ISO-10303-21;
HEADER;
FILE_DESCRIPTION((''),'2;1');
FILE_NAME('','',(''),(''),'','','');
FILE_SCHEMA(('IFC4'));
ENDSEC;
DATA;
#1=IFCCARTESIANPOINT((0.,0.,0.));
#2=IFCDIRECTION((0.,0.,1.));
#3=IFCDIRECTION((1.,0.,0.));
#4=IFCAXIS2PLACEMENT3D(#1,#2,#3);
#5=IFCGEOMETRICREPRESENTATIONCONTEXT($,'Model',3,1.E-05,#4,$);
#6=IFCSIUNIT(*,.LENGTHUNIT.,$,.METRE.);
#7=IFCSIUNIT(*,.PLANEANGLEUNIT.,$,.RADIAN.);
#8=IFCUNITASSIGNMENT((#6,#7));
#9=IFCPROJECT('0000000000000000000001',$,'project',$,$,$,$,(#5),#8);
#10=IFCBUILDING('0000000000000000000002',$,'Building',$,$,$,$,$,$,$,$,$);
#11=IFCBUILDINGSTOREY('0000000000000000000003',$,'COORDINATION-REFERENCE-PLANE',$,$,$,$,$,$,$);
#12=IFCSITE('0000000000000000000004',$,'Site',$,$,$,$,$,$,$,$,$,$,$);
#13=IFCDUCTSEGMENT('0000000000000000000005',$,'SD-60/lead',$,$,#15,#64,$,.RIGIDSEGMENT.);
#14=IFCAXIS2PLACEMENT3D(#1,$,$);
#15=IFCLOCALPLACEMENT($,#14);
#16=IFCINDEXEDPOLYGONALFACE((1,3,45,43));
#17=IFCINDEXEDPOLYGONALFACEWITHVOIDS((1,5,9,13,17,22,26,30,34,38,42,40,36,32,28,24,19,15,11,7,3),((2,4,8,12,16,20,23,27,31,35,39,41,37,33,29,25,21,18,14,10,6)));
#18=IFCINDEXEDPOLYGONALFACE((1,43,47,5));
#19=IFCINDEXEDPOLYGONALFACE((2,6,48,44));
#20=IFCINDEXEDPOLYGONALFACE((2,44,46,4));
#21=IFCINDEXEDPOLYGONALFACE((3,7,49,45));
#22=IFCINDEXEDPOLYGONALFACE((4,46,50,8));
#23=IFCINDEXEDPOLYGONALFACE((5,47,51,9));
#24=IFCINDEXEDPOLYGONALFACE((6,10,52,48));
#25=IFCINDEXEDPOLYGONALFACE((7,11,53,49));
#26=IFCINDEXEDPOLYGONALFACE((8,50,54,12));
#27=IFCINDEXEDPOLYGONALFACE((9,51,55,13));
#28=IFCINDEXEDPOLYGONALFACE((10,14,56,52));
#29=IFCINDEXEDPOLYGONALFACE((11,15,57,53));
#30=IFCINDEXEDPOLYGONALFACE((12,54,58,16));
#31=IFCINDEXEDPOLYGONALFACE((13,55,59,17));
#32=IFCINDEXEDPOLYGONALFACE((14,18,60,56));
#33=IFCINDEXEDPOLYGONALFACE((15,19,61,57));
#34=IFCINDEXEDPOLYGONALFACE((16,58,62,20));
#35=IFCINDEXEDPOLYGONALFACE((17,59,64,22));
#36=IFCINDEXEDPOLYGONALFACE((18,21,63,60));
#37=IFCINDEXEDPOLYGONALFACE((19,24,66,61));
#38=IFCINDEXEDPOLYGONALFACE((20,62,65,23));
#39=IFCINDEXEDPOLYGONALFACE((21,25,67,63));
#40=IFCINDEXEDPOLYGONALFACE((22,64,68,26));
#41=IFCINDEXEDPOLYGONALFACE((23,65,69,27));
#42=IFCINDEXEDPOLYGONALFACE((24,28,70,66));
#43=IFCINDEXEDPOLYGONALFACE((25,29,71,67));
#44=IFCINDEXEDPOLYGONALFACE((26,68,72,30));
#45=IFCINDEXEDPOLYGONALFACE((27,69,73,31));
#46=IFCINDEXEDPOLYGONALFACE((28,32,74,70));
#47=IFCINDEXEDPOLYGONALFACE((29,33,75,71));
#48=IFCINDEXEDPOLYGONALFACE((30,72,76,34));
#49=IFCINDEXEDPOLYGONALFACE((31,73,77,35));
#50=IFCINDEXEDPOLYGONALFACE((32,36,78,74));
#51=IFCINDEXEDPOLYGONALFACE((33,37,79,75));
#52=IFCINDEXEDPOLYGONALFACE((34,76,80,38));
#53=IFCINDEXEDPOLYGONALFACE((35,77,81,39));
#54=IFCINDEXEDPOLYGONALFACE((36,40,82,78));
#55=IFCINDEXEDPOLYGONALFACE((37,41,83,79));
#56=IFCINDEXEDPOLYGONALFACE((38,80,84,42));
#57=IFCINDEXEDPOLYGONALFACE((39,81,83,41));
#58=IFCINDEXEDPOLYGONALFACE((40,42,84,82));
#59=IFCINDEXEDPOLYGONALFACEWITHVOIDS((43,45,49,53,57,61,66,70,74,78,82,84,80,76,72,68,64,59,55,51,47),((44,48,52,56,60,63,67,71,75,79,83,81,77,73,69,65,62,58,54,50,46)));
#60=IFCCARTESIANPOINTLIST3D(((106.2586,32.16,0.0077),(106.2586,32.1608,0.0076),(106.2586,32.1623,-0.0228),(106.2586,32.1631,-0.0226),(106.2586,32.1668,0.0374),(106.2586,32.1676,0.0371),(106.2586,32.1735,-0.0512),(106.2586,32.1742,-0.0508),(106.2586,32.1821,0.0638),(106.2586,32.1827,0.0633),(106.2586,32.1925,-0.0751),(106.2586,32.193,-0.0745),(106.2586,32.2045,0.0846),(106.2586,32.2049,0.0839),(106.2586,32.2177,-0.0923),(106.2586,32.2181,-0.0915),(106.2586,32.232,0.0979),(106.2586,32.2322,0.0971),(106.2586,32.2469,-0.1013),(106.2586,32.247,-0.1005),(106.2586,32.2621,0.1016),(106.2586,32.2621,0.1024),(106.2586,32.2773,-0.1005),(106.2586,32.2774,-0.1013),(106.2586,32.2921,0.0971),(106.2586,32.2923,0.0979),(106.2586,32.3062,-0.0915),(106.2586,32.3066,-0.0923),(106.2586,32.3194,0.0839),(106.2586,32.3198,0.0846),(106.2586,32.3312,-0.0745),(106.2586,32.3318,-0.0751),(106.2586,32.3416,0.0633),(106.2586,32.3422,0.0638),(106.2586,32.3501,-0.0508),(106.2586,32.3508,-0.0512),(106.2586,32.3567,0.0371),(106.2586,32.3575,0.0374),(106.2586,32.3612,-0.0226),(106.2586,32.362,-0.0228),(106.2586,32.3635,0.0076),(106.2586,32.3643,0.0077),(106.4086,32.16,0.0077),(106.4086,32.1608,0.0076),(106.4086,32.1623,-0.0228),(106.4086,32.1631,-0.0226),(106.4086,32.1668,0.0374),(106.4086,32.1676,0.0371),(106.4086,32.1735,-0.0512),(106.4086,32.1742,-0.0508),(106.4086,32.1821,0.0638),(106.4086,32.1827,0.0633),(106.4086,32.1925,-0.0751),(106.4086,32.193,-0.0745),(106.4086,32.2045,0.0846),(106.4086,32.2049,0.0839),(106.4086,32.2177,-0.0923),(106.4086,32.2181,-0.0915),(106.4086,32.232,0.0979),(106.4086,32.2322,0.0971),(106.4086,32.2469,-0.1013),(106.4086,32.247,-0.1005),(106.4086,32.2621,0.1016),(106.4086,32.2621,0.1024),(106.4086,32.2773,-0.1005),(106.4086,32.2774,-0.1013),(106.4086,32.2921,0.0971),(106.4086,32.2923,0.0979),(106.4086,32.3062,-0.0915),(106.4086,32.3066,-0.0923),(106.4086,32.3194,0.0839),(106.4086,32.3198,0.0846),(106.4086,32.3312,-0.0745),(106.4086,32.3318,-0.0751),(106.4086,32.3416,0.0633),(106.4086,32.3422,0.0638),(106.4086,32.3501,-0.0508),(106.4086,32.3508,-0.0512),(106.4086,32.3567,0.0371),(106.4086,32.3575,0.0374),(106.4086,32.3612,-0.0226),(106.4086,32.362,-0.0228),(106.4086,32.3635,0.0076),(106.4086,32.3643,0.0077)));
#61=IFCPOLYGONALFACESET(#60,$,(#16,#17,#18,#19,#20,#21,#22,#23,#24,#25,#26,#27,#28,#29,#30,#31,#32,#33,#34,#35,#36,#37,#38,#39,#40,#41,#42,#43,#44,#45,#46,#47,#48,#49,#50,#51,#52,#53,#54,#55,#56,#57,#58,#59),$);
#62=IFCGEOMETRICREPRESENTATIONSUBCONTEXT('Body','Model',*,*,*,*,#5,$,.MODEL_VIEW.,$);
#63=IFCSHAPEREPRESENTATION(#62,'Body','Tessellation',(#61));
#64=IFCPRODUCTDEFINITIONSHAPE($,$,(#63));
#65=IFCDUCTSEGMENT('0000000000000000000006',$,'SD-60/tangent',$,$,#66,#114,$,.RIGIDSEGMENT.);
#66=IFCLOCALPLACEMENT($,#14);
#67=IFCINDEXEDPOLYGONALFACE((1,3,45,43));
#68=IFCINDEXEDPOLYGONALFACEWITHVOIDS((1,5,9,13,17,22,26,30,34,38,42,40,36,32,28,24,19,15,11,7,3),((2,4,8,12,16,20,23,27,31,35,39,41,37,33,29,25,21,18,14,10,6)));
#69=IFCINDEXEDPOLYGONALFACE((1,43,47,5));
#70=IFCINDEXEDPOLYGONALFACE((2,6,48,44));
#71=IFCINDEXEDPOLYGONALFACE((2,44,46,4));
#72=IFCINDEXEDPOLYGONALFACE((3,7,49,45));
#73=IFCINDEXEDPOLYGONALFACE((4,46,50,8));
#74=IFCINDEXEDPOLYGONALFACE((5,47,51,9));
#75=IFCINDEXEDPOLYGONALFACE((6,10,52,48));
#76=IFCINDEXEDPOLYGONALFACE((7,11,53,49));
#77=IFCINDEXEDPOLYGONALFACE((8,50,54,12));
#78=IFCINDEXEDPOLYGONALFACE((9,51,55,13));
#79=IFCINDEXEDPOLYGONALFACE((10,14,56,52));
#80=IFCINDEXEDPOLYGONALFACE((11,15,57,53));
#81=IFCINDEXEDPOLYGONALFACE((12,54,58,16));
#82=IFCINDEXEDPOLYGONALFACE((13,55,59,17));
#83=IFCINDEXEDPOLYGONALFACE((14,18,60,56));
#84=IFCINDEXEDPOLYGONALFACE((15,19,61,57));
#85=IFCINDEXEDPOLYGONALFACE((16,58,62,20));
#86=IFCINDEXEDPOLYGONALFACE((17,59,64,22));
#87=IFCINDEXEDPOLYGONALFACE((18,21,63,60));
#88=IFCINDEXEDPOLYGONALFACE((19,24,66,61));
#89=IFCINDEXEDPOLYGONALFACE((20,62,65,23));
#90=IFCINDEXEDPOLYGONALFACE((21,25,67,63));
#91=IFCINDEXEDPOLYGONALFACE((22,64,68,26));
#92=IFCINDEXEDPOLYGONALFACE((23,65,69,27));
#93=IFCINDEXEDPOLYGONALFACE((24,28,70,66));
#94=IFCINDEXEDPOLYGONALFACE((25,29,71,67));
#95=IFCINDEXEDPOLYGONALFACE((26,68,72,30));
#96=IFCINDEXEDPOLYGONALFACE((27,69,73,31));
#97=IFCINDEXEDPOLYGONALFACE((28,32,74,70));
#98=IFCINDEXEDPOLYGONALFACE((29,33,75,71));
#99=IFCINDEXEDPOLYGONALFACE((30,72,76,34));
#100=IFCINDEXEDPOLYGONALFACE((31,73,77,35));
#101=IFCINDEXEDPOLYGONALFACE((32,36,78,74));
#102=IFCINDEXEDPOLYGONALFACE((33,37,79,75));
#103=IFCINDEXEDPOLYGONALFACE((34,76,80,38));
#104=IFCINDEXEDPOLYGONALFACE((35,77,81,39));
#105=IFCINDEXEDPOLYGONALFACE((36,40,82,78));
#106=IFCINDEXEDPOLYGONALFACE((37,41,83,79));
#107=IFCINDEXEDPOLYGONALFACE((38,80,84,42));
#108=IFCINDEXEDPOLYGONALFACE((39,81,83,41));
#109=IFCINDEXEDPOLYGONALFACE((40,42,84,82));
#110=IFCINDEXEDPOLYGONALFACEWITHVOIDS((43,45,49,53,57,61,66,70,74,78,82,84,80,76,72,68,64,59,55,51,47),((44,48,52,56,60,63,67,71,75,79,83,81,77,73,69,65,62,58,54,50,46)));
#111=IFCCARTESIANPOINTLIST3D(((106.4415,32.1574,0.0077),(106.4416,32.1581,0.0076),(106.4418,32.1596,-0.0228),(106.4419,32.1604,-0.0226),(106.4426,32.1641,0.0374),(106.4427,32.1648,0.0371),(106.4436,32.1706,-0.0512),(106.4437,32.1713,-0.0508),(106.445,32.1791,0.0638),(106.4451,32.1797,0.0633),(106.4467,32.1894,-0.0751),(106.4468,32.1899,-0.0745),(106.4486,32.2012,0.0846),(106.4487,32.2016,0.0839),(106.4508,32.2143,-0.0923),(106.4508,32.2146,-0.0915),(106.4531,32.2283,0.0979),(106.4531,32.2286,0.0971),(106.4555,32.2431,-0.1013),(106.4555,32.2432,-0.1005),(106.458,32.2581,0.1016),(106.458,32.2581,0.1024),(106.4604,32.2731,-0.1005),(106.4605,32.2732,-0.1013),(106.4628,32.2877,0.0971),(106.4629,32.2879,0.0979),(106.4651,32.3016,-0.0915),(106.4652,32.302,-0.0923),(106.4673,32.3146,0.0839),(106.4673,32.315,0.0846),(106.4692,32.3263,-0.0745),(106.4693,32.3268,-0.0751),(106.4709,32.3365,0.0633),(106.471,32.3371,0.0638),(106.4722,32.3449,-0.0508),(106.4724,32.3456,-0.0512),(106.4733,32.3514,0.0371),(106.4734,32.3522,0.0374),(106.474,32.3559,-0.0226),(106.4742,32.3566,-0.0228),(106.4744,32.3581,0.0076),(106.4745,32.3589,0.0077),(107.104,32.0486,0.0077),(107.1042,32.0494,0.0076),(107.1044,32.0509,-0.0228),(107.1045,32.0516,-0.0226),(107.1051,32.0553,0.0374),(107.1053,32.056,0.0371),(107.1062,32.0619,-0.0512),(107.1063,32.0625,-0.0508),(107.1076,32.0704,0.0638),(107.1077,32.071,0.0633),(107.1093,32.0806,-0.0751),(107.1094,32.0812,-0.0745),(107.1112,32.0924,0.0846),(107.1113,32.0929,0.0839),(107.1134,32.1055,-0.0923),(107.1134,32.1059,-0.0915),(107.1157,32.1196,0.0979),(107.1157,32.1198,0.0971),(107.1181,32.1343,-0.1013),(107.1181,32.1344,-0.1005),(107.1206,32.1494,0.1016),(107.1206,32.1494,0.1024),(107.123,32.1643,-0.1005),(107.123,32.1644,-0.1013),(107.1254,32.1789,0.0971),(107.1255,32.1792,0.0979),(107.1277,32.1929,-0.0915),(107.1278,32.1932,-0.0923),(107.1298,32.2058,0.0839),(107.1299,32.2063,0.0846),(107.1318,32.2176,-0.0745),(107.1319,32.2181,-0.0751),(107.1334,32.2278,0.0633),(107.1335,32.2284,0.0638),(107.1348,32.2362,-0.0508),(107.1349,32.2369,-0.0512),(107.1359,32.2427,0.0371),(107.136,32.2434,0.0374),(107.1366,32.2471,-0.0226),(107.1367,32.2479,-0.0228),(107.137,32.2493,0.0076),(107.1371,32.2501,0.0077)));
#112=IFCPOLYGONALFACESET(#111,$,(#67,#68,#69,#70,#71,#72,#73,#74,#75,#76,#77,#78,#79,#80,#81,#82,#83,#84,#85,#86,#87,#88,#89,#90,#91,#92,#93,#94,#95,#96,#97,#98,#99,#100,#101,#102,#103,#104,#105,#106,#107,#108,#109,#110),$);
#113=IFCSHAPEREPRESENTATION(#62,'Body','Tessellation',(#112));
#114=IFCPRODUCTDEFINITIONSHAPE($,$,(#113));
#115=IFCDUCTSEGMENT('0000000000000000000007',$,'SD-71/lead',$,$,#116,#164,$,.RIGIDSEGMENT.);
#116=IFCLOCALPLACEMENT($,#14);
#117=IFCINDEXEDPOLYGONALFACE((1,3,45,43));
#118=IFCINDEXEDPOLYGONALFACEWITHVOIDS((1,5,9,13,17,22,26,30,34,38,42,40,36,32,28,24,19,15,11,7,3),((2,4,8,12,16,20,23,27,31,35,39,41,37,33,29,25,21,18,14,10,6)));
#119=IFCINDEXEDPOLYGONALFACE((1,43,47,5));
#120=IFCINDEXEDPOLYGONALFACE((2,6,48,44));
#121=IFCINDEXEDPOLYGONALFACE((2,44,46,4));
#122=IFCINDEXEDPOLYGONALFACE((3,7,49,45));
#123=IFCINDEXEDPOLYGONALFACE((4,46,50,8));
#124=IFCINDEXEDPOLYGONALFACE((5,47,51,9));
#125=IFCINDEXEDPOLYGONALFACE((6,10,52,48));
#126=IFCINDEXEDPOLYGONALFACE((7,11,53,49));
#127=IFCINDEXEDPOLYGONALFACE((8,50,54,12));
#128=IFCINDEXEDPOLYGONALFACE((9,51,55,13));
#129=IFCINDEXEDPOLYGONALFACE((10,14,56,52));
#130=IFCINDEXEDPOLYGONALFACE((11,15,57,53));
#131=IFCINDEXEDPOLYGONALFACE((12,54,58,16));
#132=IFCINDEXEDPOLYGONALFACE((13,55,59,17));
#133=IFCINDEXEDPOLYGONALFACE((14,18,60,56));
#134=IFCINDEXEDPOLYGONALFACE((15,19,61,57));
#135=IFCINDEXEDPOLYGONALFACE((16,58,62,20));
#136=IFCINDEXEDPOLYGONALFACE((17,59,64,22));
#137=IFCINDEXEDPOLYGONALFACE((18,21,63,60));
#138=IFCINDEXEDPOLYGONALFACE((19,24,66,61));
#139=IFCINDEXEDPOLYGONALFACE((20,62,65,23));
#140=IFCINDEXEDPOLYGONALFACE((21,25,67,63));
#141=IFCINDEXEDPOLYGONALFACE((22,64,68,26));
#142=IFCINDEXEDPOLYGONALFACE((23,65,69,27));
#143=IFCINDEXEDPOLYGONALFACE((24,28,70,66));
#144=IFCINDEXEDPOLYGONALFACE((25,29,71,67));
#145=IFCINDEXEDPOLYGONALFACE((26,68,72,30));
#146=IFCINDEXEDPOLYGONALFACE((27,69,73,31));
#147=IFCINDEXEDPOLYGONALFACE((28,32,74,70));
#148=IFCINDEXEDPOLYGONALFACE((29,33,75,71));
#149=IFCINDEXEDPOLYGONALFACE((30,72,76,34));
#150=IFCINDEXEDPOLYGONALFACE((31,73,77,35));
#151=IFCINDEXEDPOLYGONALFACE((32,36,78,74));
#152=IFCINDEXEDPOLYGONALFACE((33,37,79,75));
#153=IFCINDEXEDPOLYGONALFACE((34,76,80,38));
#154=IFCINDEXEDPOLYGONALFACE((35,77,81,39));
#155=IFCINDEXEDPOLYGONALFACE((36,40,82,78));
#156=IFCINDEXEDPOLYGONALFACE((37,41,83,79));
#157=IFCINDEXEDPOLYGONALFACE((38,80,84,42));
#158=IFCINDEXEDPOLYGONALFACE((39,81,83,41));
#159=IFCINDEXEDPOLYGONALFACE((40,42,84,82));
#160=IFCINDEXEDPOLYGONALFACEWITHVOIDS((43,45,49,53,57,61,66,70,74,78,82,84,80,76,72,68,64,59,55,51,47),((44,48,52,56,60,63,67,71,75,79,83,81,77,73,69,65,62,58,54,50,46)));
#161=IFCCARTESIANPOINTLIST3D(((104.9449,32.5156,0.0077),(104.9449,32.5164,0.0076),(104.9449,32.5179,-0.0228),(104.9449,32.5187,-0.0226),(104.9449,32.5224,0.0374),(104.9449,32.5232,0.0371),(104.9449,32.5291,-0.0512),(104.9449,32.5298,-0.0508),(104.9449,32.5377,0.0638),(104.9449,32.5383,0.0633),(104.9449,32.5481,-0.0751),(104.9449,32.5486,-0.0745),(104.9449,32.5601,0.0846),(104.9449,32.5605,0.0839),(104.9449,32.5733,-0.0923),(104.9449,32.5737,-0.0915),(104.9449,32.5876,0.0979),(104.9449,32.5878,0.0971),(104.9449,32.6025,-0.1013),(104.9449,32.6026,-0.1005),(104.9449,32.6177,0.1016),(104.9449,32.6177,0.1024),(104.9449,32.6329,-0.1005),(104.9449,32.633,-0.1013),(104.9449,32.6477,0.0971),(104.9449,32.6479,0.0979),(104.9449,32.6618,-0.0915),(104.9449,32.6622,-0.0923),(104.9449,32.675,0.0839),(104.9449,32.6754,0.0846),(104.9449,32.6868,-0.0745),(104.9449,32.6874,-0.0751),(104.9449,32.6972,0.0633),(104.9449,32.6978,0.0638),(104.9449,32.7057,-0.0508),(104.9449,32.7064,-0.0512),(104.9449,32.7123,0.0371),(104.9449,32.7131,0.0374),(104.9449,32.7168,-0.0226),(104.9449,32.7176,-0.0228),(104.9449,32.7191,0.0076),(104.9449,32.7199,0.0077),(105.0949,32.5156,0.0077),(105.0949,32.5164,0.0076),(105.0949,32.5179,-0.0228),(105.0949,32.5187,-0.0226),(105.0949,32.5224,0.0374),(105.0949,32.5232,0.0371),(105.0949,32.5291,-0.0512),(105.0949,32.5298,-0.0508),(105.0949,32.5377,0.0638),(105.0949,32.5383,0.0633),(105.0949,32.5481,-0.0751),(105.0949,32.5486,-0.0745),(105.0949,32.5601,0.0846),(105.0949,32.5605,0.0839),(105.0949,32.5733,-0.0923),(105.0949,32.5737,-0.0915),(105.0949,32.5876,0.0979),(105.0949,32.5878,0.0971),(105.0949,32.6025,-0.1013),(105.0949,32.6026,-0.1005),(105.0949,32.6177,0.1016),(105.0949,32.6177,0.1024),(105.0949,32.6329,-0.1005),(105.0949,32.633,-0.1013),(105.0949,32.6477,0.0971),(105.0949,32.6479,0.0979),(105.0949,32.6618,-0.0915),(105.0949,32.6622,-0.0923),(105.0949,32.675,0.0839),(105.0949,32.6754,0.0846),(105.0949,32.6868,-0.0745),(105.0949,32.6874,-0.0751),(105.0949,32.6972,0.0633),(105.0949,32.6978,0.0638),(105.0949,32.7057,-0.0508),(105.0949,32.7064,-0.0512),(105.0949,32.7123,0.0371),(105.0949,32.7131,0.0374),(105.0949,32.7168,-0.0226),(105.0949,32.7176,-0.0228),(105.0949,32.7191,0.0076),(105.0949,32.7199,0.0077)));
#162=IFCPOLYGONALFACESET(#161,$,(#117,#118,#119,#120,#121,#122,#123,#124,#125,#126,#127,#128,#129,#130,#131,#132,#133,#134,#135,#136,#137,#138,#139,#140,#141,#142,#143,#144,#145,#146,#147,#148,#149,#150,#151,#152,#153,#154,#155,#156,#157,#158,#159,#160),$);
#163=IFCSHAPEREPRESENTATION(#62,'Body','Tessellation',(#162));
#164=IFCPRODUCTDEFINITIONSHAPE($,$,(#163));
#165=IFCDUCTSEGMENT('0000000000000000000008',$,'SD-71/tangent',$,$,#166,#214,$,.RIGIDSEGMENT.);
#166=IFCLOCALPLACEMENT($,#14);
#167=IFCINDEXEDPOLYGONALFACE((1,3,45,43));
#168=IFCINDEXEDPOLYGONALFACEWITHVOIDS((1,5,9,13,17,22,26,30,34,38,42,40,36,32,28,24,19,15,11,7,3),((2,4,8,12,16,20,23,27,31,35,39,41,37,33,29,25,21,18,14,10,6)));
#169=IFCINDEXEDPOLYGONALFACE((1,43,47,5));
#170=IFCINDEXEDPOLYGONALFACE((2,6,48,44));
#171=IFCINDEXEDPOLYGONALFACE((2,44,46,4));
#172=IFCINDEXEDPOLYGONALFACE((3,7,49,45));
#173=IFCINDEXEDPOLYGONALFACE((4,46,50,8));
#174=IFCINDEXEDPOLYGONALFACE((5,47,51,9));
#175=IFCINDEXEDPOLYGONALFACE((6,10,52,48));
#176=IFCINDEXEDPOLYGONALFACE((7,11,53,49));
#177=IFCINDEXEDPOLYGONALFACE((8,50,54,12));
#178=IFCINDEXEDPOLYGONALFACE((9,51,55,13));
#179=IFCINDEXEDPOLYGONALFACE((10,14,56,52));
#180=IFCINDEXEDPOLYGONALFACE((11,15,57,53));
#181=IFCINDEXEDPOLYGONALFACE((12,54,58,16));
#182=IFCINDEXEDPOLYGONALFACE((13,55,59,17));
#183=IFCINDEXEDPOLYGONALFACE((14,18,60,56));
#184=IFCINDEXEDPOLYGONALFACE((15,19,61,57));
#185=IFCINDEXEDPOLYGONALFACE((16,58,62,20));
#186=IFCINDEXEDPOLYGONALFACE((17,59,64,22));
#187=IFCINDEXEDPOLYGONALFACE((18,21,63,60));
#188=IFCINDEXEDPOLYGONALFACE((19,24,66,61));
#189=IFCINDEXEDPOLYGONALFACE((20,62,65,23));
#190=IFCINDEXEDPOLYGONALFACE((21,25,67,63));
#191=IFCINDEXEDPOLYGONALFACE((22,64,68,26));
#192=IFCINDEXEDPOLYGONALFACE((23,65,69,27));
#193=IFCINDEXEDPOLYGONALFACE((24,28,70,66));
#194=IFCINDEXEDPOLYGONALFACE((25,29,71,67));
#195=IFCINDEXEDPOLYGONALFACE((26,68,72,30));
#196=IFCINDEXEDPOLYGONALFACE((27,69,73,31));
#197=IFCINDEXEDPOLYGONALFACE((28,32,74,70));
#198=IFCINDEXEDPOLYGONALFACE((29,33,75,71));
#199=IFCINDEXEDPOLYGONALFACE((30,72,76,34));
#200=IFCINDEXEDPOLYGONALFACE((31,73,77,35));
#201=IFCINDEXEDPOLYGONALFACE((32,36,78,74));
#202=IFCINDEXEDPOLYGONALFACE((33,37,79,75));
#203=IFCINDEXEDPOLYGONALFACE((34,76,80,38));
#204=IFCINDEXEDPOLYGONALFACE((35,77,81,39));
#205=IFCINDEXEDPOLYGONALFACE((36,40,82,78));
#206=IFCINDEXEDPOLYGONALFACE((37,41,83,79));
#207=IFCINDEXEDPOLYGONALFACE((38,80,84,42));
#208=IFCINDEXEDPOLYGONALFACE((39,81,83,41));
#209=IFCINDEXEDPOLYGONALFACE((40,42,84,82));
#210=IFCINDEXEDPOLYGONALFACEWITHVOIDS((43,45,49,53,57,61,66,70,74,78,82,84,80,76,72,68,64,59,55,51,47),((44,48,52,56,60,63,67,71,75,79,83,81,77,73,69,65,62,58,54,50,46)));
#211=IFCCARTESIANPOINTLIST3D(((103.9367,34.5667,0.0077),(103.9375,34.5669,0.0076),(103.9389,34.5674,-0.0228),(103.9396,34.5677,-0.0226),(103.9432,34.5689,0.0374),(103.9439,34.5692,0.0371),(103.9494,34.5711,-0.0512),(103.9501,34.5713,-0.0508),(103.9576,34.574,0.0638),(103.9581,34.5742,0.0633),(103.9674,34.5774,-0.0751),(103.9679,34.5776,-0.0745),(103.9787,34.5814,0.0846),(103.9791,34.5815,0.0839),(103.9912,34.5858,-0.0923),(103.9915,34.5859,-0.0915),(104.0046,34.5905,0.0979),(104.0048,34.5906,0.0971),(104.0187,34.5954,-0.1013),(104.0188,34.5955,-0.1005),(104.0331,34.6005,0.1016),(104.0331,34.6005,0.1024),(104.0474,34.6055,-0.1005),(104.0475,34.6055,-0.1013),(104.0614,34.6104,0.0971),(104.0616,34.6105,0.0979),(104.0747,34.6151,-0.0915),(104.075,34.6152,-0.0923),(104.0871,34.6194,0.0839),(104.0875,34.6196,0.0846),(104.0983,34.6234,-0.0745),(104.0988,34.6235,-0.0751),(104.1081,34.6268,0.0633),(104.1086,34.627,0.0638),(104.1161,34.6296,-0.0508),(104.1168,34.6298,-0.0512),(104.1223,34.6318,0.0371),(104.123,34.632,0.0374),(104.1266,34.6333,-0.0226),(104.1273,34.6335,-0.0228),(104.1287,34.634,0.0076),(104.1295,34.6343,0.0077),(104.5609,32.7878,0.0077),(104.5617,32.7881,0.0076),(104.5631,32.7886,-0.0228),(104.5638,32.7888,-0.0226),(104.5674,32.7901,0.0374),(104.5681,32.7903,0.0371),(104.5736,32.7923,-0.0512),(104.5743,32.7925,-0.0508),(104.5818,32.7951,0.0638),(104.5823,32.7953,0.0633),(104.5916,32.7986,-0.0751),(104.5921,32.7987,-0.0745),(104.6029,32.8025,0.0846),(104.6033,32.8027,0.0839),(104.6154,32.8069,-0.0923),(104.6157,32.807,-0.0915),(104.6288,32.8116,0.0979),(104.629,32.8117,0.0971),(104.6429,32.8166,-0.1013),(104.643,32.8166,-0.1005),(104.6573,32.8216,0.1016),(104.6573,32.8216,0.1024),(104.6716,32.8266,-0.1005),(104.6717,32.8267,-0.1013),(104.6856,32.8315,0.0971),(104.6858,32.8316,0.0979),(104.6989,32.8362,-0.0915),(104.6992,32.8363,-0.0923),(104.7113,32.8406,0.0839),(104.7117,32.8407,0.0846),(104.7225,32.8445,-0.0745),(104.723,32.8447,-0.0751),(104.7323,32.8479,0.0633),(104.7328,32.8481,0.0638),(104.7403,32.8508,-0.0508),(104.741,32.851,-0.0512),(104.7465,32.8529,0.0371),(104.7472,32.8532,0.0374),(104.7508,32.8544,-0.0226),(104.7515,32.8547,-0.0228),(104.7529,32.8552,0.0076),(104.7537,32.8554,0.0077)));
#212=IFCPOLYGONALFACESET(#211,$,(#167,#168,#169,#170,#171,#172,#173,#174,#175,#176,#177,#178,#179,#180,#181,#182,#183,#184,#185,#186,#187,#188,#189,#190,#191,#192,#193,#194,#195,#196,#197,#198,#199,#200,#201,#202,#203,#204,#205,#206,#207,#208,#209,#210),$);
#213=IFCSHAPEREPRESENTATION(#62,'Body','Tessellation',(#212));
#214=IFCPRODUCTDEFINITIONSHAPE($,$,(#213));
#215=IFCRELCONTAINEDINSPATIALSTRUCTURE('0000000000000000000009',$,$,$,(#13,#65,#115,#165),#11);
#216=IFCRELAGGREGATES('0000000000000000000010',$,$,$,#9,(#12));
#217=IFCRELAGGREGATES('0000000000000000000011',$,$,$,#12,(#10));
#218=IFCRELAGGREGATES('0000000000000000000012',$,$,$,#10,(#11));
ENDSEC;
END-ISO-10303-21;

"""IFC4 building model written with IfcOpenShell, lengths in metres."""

from ifc_helpers import new_model, si_unit, frame, origin_with_axes, place, context, subcontext, project, spatial, hollow_circle, extrude, element, save


model = new_model("IFC4")

# Units and contexts
model_context = context("Model", 3, precision=1e-05, world=origin_with_axes())
body_context_1 = subcontext(model_context, "Body", "Model", "MODEL_VIEW")
ifc_project = project(units=[si_unit("LENGTHUNIT", "METRE"), si_unit("PLANEANGLEUNIT", "RADIAN")], contexts=[model_context])

# Site, building, storey
site = spatial("IfcSite", under=ifc_project, Name="Site")
building = spatial("IfcBuilding", under=site, Name="Building")
storey = spatial("IfcBuildingStorey", under=building, Name="COORDINATION-REFERENCE-PLANE")

# Duct segment
duct_segment_1_placement = place(None, frame((106.2586, 32.2621, 0.0), z_axis=(1.0, 0.0, 0.0), x_axis=(0.0, 0.0, 1.0)))
element("IfcDuctSegment", 1, at=duct_segment_1_placement, inside=storey, Name="SD-60/lead", PredefinedType="RIGIDSEGMENT", context=body_context_1, shape_type="SweptSolid", body=[
    extrude(hollow_circle(Radius=0.1024, WallThickness=0.0008), origin_with_axes(), (0.0, 0.0, 1.0), 0.15),
])

# Duct segment
duct_segment_2_placement = place(None, frame((106.458, 32.2581, 0.0), z_axis=(0.986797, -0.161964, 0.0), x_axis=(0.0, 0.0, 1.0)))
element("IfcDuctSegment", 2, at=duct_segment_2_placement, inside=storey, Name="SD-60/tangent", PredefinedType="RIGIDSEGMENT", context=body_context_1, shape_type="SweptSolid", body=[
    extrude(hollow_circle(Radius=0.1024, WallThickness=0.0008), origin_with_axes(), (0.0, 0.0, 1.0), 0.6714),
])

# Duct segment
duct_segment_3_placement = place(None, frame((105.0949, 32.6177, 0.0), z_axis=(-1.0, 0.0, 0.0), x_axis=(0.0, 0.0, 1.0)))
element("IfcDuctSegment", 3, at=duct_segment_3_placement, inside=storey, Name="SD-71/lead", PredefinedType="RIGIDSEGMENT", context=body_context_1, shape_type="SweptSolid", body=[
    extrude(hollow_circle(Radius=0.1024, WallThickness=0.0008), origin_with_axes(), (0.0, 0.0, 1.0), 0.15),
])

# Duct segment
duct_segment_4_placement = place(None, frame((104.6573, 32.8216, 0.0), z_axis=(-0.331106, 0.943594, 0.0), x_axis=(0.0, 0.0, 1.0)))
element("IfcDuctSegment", 4, at=duct_segment_4_placement, inside=storey, Name="SD-71/tangent", PredefinedType="RIGIDSEGMENT", context=body_context_1, shape_type="SweptSolid", body=[
    extrude(hollow_circle(Radius=0.1024, WallThickness=0.0008), origin_with_axes(), (0.0, 0.0, 1.0), 1.8852),
])

save(model, "model.ifc")
